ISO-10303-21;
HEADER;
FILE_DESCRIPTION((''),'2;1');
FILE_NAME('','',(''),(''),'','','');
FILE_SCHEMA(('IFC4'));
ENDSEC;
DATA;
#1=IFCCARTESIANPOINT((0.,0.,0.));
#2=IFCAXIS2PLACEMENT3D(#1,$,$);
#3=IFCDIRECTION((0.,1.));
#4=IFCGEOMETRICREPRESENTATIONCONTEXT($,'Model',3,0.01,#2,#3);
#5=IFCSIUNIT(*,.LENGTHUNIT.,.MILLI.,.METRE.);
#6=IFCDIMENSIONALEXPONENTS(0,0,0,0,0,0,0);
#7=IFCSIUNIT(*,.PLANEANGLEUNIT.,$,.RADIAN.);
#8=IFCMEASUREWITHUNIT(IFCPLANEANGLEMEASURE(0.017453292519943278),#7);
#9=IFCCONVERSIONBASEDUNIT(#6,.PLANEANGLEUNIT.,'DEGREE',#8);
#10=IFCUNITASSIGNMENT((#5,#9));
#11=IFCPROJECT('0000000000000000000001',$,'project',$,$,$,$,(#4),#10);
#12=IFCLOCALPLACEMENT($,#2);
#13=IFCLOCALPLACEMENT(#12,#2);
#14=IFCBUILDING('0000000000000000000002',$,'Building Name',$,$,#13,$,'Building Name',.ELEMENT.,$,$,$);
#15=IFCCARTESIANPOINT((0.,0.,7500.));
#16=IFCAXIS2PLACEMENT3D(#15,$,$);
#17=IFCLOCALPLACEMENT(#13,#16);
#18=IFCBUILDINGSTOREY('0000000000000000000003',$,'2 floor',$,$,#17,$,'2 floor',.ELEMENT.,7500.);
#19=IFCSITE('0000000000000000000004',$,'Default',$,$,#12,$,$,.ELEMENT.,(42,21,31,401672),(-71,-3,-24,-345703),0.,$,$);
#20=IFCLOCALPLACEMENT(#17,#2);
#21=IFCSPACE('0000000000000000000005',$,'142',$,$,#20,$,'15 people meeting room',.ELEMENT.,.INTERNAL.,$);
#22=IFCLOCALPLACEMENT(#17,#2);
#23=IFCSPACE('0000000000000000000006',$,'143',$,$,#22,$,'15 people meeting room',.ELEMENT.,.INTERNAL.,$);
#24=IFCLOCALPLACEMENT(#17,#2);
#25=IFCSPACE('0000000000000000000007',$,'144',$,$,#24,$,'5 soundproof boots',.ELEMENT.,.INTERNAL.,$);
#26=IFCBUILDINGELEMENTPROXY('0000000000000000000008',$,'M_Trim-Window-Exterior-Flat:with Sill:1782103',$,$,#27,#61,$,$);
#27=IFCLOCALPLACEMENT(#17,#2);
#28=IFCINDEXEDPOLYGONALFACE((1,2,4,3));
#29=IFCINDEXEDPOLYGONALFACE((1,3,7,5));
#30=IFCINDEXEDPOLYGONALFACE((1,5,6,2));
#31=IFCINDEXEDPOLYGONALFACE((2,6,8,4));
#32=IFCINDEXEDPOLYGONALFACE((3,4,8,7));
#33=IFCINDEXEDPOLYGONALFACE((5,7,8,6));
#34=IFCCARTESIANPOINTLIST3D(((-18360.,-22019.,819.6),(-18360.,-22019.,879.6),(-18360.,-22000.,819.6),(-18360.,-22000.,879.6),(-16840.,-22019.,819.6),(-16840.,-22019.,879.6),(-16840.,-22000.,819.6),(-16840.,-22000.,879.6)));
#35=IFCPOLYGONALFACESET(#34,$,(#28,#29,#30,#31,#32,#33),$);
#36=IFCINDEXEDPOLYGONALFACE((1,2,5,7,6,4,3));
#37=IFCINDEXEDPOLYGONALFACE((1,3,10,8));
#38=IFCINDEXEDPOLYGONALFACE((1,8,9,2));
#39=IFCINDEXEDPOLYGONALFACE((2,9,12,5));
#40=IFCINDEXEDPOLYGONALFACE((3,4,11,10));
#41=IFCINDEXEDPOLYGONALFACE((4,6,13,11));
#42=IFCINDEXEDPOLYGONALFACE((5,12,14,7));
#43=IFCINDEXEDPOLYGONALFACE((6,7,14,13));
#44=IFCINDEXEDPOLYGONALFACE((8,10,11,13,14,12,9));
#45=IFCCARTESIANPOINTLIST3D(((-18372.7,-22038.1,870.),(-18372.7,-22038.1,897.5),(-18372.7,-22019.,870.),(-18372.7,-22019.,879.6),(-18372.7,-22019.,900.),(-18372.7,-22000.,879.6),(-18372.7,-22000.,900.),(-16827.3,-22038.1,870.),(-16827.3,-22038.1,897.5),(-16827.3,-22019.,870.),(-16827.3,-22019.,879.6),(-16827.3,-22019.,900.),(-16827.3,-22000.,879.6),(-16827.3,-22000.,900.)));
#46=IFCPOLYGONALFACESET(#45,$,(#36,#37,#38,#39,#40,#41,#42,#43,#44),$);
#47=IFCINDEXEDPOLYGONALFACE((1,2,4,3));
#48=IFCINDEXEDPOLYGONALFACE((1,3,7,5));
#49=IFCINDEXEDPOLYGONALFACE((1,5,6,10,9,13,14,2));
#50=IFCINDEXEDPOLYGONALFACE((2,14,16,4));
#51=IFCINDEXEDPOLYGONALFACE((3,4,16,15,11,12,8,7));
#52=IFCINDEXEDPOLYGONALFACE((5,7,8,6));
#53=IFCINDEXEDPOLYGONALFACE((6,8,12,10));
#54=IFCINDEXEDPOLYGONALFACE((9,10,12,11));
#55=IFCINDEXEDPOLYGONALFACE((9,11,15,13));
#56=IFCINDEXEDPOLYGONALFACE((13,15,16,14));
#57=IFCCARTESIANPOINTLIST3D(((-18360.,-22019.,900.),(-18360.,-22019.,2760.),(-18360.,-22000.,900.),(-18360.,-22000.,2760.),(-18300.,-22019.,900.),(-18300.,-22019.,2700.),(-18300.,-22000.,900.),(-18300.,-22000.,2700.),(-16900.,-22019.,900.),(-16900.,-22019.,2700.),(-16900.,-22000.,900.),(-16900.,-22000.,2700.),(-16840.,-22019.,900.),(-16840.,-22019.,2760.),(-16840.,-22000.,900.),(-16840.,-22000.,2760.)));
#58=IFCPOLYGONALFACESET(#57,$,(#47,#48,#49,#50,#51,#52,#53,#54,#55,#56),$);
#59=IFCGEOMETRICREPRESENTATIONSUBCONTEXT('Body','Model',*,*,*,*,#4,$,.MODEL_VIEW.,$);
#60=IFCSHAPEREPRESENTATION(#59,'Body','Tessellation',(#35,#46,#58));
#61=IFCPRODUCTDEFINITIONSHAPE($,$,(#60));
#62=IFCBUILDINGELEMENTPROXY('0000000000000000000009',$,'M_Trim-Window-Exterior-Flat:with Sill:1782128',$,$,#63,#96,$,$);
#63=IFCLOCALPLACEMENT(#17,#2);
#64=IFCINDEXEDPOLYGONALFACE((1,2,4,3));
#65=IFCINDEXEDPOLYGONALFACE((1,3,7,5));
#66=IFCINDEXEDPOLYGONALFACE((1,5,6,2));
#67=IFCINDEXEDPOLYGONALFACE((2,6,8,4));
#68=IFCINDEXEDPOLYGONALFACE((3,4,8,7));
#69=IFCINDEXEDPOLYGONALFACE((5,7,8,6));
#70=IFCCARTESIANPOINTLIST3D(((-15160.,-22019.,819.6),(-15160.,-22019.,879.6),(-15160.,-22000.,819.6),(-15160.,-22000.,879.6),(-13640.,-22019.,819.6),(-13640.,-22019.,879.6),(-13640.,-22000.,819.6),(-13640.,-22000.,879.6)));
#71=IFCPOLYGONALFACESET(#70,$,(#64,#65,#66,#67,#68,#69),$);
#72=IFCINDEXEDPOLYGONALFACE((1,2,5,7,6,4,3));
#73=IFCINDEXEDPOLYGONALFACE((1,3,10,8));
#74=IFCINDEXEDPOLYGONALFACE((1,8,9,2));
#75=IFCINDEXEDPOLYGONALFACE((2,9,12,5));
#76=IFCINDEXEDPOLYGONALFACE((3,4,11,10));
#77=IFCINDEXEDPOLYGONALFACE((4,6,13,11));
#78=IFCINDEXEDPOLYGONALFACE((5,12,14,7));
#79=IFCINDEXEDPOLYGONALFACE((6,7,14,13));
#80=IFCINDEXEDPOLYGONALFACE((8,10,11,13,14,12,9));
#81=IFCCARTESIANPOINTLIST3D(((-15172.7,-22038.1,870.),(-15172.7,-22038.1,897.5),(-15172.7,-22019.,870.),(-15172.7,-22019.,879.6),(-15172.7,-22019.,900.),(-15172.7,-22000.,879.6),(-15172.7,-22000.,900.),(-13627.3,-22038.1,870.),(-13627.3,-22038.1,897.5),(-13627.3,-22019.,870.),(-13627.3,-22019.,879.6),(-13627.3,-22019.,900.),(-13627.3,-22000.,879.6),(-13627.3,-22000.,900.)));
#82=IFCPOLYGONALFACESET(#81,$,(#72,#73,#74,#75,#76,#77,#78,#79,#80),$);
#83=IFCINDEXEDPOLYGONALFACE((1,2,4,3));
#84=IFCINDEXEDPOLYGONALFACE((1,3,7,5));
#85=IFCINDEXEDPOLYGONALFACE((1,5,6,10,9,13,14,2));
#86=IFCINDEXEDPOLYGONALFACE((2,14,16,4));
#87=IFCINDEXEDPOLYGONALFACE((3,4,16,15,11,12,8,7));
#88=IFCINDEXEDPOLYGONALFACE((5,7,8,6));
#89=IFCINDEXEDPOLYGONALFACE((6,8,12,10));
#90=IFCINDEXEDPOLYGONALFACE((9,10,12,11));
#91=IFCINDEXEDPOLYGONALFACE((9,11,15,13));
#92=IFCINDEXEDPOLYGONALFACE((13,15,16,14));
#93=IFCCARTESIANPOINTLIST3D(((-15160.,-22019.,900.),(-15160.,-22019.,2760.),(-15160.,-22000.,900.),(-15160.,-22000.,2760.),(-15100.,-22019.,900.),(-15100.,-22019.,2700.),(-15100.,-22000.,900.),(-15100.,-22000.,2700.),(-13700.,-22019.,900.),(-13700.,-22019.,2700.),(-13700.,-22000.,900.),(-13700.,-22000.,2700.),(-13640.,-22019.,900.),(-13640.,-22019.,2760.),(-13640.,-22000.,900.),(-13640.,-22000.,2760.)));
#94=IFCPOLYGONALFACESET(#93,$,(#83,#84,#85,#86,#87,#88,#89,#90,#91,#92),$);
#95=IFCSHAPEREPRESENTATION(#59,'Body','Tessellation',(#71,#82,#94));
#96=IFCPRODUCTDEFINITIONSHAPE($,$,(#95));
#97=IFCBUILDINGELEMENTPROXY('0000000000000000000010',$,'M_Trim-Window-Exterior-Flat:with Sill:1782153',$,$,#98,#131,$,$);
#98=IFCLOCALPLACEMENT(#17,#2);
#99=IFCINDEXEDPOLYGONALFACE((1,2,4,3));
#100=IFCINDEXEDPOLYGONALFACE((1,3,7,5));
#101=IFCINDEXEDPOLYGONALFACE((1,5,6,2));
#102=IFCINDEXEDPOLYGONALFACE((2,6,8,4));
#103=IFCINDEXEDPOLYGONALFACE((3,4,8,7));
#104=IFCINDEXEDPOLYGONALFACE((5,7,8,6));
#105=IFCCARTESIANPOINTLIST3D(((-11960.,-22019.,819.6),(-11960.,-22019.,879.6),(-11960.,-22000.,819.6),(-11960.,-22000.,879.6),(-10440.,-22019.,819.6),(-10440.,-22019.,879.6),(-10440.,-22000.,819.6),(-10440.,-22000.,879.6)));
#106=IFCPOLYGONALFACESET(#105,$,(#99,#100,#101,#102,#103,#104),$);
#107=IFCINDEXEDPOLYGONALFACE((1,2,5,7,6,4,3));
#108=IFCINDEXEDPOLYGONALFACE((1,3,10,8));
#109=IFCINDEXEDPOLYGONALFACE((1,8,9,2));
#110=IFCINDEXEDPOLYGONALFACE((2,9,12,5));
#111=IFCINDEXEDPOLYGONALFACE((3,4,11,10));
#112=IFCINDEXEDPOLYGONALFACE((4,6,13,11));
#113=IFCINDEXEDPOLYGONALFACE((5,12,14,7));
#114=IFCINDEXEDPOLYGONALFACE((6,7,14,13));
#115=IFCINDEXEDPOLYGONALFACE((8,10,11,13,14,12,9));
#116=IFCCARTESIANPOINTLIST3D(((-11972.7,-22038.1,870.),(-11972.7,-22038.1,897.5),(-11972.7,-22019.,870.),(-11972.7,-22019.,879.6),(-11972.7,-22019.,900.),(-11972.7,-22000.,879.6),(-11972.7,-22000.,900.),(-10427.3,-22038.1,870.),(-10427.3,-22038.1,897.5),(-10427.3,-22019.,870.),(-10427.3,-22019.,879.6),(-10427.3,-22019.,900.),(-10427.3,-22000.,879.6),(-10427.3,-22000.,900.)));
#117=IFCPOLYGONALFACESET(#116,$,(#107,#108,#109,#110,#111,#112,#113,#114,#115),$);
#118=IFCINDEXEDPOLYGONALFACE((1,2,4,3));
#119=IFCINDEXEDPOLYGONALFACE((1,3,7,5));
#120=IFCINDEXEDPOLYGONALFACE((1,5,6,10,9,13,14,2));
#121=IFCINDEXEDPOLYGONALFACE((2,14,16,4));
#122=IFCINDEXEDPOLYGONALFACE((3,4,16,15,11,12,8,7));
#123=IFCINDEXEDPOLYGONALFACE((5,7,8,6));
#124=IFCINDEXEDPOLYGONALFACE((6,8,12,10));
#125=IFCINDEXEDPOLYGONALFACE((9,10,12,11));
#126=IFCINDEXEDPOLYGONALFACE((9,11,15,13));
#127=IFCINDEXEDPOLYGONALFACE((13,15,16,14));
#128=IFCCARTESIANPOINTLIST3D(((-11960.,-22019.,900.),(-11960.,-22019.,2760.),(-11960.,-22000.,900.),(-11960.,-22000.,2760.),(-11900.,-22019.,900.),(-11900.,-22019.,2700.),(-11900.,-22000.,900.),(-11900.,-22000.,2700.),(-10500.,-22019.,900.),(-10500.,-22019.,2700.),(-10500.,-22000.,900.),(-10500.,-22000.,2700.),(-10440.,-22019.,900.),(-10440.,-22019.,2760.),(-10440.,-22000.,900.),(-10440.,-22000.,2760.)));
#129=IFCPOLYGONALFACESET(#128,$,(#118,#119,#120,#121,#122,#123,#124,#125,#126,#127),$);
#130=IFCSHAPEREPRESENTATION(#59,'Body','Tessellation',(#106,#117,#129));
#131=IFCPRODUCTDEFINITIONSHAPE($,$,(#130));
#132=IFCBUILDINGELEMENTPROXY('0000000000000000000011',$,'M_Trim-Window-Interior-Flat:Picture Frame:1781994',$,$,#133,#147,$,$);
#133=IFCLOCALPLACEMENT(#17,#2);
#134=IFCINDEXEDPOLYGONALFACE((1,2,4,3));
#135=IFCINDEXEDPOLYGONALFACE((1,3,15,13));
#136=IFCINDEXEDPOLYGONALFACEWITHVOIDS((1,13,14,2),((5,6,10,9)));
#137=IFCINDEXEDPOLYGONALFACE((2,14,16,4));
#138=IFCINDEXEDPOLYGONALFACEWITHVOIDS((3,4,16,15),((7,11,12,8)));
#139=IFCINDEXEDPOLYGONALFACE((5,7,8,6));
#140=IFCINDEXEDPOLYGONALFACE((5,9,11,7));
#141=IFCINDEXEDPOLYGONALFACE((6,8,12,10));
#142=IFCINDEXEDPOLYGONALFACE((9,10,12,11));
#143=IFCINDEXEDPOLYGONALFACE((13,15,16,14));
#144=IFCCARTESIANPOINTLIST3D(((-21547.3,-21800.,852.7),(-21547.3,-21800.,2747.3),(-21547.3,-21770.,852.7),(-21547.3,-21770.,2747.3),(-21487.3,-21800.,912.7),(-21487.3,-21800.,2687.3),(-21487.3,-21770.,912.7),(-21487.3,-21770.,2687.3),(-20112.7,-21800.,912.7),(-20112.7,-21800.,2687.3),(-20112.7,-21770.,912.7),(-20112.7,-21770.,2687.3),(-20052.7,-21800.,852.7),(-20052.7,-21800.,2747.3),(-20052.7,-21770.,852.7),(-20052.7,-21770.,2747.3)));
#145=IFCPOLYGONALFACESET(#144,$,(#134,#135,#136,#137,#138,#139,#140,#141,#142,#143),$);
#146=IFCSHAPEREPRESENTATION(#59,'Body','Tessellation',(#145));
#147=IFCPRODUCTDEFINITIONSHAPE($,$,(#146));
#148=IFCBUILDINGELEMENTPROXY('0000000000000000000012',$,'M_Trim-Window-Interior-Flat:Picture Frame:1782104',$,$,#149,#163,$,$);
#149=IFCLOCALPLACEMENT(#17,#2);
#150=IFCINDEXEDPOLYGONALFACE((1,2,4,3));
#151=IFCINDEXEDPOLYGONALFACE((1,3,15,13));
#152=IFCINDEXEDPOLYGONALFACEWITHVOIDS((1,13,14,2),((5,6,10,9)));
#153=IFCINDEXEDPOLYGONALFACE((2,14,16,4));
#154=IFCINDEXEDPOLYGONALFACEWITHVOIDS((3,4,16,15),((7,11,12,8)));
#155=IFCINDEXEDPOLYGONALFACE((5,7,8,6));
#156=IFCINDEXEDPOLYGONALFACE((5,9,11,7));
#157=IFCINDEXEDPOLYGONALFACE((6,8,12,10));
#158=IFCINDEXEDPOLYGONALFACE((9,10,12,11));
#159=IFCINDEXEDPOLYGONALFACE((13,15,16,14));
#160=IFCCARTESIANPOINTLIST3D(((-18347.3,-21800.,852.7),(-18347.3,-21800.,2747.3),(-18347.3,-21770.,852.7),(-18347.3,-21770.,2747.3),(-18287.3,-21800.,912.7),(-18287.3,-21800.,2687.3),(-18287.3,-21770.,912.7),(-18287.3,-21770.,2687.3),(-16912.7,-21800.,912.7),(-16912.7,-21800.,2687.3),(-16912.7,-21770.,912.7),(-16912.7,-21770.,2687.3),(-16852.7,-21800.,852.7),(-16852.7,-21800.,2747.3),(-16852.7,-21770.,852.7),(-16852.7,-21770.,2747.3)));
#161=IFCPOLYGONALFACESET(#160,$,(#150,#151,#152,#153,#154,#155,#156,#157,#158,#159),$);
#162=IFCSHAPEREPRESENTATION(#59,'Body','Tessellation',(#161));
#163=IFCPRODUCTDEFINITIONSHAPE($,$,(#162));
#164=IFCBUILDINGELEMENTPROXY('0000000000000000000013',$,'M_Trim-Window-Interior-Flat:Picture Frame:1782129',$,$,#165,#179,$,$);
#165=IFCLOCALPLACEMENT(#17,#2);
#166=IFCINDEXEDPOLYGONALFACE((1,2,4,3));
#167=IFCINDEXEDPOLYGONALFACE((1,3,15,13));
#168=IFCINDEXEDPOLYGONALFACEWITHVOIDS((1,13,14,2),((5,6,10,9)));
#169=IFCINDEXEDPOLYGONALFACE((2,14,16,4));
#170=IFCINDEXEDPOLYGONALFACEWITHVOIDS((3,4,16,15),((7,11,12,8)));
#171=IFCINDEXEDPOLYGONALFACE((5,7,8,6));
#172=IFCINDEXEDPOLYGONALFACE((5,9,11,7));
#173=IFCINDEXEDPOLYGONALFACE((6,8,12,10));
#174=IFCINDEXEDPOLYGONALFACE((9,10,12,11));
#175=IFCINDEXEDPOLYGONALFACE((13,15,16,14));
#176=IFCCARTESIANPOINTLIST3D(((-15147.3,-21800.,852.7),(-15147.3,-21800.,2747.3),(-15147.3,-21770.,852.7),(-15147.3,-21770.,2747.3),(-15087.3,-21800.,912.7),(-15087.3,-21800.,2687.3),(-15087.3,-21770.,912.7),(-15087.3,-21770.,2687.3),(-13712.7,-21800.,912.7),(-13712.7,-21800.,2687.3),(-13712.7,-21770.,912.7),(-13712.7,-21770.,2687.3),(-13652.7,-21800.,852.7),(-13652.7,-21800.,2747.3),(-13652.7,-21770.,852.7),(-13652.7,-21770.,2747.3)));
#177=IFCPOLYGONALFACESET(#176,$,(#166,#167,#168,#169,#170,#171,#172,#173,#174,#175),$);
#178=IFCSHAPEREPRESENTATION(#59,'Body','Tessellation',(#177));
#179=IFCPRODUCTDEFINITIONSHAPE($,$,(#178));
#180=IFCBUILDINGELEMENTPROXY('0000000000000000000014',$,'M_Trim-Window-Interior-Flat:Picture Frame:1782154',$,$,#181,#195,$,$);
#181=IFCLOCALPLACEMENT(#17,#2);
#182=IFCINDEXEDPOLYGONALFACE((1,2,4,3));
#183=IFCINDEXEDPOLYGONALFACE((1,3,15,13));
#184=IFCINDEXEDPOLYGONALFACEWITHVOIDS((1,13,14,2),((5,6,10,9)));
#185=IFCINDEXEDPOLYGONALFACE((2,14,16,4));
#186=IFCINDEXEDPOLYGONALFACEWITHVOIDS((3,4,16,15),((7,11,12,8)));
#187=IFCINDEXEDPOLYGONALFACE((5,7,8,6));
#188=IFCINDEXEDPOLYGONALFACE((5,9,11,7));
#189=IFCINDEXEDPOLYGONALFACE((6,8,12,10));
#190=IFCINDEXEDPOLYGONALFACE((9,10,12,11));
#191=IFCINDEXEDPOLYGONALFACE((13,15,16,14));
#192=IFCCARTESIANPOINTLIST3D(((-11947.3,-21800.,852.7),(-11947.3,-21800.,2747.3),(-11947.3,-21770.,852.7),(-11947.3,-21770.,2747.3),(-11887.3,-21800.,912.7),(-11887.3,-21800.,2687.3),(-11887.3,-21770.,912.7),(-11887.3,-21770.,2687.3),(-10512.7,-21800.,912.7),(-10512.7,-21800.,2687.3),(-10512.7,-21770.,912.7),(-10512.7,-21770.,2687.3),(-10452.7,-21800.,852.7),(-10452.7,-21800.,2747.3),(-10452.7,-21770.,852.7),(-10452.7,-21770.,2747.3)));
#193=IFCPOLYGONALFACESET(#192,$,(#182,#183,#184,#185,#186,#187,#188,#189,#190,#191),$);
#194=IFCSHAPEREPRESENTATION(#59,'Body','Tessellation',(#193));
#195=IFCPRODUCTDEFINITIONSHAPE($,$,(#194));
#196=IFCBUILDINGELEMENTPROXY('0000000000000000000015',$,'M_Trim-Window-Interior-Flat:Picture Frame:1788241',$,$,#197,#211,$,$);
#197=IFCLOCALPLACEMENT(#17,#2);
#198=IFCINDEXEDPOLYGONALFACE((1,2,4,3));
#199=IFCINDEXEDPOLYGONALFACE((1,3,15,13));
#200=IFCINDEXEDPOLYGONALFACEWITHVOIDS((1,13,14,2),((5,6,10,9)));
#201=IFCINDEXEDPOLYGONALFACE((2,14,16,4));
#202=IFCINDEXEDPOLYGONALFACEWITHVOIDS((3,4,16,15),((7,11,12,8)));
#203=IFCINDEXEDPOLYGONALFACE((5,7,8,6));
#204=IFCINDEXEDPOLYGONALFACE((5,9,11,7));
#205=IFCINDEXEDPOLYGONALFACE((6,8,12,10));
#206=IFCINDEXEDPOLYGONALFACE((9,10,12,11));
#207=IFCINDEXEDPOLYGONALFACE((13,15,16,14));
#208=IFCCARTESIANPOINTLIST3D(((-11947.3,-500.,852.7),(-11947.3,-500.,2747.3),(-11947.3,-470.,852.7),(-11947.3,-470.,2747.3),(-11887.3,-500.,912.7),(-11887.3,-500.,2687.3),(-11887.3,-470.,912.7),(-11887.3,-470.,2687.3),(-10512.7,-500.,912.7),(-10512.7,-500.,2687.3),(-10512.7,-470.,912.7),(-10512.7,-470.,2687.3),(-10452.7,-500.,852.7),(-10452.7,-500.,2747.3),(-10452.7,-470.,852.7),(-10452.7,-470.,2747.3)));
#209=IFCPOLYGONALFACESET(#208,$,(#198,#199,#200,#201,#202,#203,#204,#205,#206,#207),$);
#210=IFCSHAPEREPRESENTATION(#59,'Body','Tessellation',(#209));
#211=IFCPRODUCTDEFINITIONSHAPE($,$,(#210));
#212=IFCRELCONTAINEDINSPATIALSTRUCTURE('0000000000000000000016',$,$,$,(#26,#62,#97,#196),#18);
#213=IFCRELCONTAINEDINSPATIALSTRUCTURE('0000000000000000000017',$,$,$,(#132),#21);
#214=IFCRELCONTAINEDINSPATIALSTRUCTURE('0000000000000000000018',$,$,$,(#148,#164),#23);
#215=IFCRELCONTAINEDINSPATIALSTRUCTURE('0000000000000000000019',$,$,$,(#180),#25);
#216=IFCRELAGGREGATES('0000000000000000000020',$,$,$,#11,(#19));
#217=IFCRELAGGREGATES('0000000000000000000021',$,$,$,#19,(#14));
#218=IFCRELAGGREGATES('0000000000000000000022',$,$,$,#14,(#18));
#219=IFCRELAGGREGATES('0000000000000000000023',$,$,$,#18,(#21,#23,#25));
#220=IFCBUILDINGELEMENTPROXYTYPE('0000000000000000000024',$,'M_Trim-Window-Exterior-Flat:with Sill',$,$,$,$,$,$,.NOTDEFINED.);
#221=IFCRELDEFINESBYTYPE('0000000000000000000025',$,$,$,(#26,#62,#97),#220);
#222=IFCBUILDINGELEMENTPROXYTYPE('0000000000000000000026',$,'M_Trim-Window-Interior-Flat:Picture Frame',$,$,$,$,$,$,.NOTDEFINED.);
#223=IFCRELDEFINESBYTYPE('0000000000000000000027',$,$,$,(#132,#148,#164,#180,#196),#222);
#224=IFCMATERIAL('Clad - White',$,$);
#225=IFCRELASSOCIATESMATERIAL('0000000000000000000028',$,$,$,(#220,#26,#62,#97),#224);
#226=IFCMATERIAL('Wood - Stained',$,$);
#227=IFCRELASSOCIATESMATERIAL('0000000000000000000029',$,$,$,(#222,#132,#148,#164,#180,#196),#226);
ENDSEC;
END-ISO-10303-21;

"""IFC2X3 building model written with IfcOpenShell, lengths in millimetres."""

from ifc_helpers import new_model, entity, si_unit, converted_unit, direction, frame, frame_2d, origin, place, context, subcontext, project, spatial, polyline, rectangle, outline, extrude, source, transform, mapped, material, type_object, type_shapes, element, save


model = new_model("IFC2X3")

# Units and contexts
model_context = context("Model", 3, precision=0.01, world=origin(), true_north=direction((0.0, 1.0)))
body_context = subcontext(model_context, "Body", "Model", "MODEL_VIEW")
ifc_project = project(units=[si_unit("LENGTHUNIT", "METRE", prefix="MILLI"), converted_unit("PLANEANGLEUNIT", "DEGREE", entity("IfcPlaneAngleMeasure", 0.017453292519943278), si_unit("PLANEANGLEUNIT", "RADIAN"), dimensions=[0, 0, 0, 0, 0, 0, 0])], contexts=[model_context])

# Site, building, storey
site_placement = place(None, origin())
site = spatial("IfcSite", under=ifc_project, at=site_placement, Name="Default", CompositionType="ELEMENT", RefLatitude=(42, 21, 31, 401672), RefLongitude=(-71, -3, -24, -345703), RefElevation=0.0)
building_placement = place(site_placement, origin())
building = spatial("IfcBuilding", under=site, at=building_placement, Name="Building Name", LongName="Building Name", CompositionType="ELEMENT")
storey_placement = place(building_placement, frame((0.0, 0.0, 7500.0)))
storey = spatial("IfcBuildingStorey", under=building, at=storey_placement, Name="2 floor", LongName="2 floor", CompositionType="ELEMENT", Elevation=7500.0)

# Building element proxies
ifc_material_1 = material(Name="Clad - White")
ifc_material_2 = material(Name="Wood - Stained")
building_element_proxy_type_1 = type_object("IfcBuildingElementProxyType", Name="M_Trim-Window-Exterior-Flat:with Sill", PredefinedType="NOTDEFINED", material=ifc_material_1)
shared_shape_1 = source(origin(), body_context, "Body", "SweptSolid", [
    extrude(rectangle(XDim=1520.0, YDim=60.0, at=frame_2d((0.0, 0.0), x_axis=(1.0, 0.0))), frame((0.0, -1850.4, 0.0), z_axis=(0.0, 0.0, 1.0), x_axis=(-1.0, 0.0, 0.0)), (0.0, 0.0, 1.0), 19.0),
    extrude(outline(polyline([(-19.0, -15.2), (0.0, -15.2), (0.0, -5.7), (19.0, -5.7), (19.0, 14.8), (0.0, 14.8), (-19.0, 12.3), (-19.0, -15.2)])), frame((-772.7, -1814.8, 19.0), z_axis=(1.0, 0.0, 0.0), x_axis=(0.0, 0.0, -1.0)), (0.0, 0.0, 1.0), 1545.4),
    extrude(outline(polyline([(-945.0, -760.0), (915.0, -760.0), (915.0, -700.0), (-885.0, -700.0), (-885.0, 700.0), (915.0, 700.0), (915.0, 760.0), (-945.0, 760.0), (-945.0, -760.0)])), frame((0.0, -885.0, 0.0), z_axis=(0.0, 0.0, 1.0), x_axis=(0.0, -1.0, 0.0)), (0.0, 0.0, 1.0), 19.0),
])
type_shapes(building_element_proxy_type_1, [shared_shape_1])
for number, where, z_axis, x_axis, name in (
    (1, (-17600.0, -22000.0, 2700.0), (0.0, -1.0, 0.0), (1.0, 0.0, 0.0), "M_Trim-Window-Exterior-Flat:with Sill:1782103"),
    (2, (-14400.0, -22000.0, 2700.0), (0.0, -1.0, 0.0), (1.0, 0.0, 0.0), "M_Trim-Window-Exterior-Flat:with Sill:1782128"),
    (3, (-11200.0, -22000.0, 2700.0), (0.0, -1.0, 0.0), (1.0, 0.0, 0.0), "M_Trim-Window-Exterior-Flat:with Sill:1782153"),
):
    element("IfcBuildingElementProxy", number, at=place(storey_placement, frame(where, z_axis=z_axis, x_axis=x_axis)), inside=storey, type_object=building_element_proxy_type_1, material=ifc_material_1, Name=name, context=body_context, shape_type="MappedRepresentation", body=[
        mapped(shared_shape_1, transform((0.0, 0.0, 0.0), scale=1.0)),
    ])

# Shared definitions
space_1_placement = place(storey_placement, origin())
space_1 = spatial("IfcSpace", under=storey, at=space_1_placement, Name="142", LongName="15 people meeting room", CompositionType="ELEMENT", InteriorOrExteriorSpace="INTERNAL")

# Building element proxy
building_element_proxy_type_2 = type_object("IfcBuildingElementProxyType", Name="M_Trim-Window-Interior-Flat:Picture Frame", PredefinedType="NOTDEFINED", material=ifc_material_2)
shared_shape_2 = source(origin(), body_context, "Body", "SweptSolid", [
    extrude(outline(polyline([(-747.3, -947.3), (747.3, -947.3), (747.3, 947.3), (-747.3, 947.3), (-747.3, -947.3)]), holes=[polyline([(-687.3, -887.3), (-687.3, 887.3), (687.3, 887.3), (687.3, -887.3), (-687.3, -887.3)])]), frame((0.0, -900.0, 0.0), z_axis=(0.0, 0.0, 1.0), x_axis=(-1.0, 0.0, 0.0)), (0.0, 0.0, 1.0), 30.0),
])
type_shapes(building_element_proxy_type_2, [shared_shape_2])
proxy_1_placement = place(space_1_placement, frame((-20800.0, -21800.0, 2700.0), z_axis=(0.0, 1.0, 0.0), x_axis=(-1.0, 0.0, 0.0)))
element("IfcBuildingElementProxy", 4, at=proxy_1_placement, inside=space_1, type_object=building_element_proxy_type_2, material=ifc_material_2, Name="M_Trim-Window-Interior-Flat:Picture Frame:1781994", context=body_context, shape_type="MappedRepresentation", body=[
    mapped(shared_shape_2, transform((0.0, 0.0, 0.0), scale=1.0)),
])

# Shared definitions
space_2_placement = place(storey_placement, origin())
space_2 = spatial("IfcSpace", under=storey, at=space_2_placement, Name="143", LongName="15 people meeting room", CompositionType="ELEMENT", InteriorOrExteriorSpace="INTERNAL")

# Building element proxies
for number, where, z_axis, x_axis, name in (
    (5, (-17600.0, -21800.0, 2700.0), (0.0, 1.0, 0.0), (-1.0, 0.0, 0.0), "M_Trim-Window-Interior-Flat:Picture Frame:1782104"),
    (6, (-14400.0, -21800.0, 2700.0), (0.0, 1.0, 0.0), (-1.0, 0.0, 0.0), "M_Trim-Window-Interior-Flat:Picture Frame:1782129"),
):
    element("IfcBuildingElementProxy", number, at=place(space_2_placement, frame(where, z_axis=z_axis, x_axis=x_axis)), inside=space_2, type_object=building_element_proxy_type_2, material=ifc_material_2, Name=name, context=body_context, shape_type="MappedRepresentation", body=[
        mapped(shared_shape_2, transform((0.0, 0.0, 0.0), scale=1.0)),
    ])

# Shared definitions
space_3_placement = place(storey_placement, origin())
space_3 = spatial("IfcSpace", under=storey, at=space_3_placement, Name="144", LongName="5 soundproof boots", CompositionType="ELEMENT", InteriorOrExteriorSpace="INTERNAL")

# Building element proxies
proxy_2_placement = place(space_3_placement, frame((-11200.0, -21800.0, 2700.0), z_axis=(0.0, 1.0, 0.0), x_axis=(-1.0, 0.0, 0.0)))
element("IfcBuildingElementProxy", 7, at=proxy_2_placement, inside=space_3, type_object=building_element_proxy_type_2, material=ifc_material_2, Name="M_Trim-Window-Interior-Flat:Picture Frame:1782154", context=body_context, shape_type="MappedRepresentation", body=[
    mapped(shared_shape_2, transform((0.0, 0.0, 0.0), scale=1.0)),
])
proxy_3_placement = place(storey_placement, frame((-11200.0, -470.0, 2700.0), z_axis=(0.0, -1.0, 0.0), x_axis=(1.0, 0.0, 0.0)))
element("IfcBuildingElementProxy", 8, at=proxy_3_placement, inside=storey, type_object=building_element_proxy_type_2, material=ifc_material_2, Name="M_Trim-Window-Interior-Flat:Picture Frame:1788241", context=body_context, shape_type="MappedRepresentation", body=[
    mapped(shared_shape_2, transform((0.0, 0.0, 0.0), scale=1.0)),
])

save(model, "model.ifc")
